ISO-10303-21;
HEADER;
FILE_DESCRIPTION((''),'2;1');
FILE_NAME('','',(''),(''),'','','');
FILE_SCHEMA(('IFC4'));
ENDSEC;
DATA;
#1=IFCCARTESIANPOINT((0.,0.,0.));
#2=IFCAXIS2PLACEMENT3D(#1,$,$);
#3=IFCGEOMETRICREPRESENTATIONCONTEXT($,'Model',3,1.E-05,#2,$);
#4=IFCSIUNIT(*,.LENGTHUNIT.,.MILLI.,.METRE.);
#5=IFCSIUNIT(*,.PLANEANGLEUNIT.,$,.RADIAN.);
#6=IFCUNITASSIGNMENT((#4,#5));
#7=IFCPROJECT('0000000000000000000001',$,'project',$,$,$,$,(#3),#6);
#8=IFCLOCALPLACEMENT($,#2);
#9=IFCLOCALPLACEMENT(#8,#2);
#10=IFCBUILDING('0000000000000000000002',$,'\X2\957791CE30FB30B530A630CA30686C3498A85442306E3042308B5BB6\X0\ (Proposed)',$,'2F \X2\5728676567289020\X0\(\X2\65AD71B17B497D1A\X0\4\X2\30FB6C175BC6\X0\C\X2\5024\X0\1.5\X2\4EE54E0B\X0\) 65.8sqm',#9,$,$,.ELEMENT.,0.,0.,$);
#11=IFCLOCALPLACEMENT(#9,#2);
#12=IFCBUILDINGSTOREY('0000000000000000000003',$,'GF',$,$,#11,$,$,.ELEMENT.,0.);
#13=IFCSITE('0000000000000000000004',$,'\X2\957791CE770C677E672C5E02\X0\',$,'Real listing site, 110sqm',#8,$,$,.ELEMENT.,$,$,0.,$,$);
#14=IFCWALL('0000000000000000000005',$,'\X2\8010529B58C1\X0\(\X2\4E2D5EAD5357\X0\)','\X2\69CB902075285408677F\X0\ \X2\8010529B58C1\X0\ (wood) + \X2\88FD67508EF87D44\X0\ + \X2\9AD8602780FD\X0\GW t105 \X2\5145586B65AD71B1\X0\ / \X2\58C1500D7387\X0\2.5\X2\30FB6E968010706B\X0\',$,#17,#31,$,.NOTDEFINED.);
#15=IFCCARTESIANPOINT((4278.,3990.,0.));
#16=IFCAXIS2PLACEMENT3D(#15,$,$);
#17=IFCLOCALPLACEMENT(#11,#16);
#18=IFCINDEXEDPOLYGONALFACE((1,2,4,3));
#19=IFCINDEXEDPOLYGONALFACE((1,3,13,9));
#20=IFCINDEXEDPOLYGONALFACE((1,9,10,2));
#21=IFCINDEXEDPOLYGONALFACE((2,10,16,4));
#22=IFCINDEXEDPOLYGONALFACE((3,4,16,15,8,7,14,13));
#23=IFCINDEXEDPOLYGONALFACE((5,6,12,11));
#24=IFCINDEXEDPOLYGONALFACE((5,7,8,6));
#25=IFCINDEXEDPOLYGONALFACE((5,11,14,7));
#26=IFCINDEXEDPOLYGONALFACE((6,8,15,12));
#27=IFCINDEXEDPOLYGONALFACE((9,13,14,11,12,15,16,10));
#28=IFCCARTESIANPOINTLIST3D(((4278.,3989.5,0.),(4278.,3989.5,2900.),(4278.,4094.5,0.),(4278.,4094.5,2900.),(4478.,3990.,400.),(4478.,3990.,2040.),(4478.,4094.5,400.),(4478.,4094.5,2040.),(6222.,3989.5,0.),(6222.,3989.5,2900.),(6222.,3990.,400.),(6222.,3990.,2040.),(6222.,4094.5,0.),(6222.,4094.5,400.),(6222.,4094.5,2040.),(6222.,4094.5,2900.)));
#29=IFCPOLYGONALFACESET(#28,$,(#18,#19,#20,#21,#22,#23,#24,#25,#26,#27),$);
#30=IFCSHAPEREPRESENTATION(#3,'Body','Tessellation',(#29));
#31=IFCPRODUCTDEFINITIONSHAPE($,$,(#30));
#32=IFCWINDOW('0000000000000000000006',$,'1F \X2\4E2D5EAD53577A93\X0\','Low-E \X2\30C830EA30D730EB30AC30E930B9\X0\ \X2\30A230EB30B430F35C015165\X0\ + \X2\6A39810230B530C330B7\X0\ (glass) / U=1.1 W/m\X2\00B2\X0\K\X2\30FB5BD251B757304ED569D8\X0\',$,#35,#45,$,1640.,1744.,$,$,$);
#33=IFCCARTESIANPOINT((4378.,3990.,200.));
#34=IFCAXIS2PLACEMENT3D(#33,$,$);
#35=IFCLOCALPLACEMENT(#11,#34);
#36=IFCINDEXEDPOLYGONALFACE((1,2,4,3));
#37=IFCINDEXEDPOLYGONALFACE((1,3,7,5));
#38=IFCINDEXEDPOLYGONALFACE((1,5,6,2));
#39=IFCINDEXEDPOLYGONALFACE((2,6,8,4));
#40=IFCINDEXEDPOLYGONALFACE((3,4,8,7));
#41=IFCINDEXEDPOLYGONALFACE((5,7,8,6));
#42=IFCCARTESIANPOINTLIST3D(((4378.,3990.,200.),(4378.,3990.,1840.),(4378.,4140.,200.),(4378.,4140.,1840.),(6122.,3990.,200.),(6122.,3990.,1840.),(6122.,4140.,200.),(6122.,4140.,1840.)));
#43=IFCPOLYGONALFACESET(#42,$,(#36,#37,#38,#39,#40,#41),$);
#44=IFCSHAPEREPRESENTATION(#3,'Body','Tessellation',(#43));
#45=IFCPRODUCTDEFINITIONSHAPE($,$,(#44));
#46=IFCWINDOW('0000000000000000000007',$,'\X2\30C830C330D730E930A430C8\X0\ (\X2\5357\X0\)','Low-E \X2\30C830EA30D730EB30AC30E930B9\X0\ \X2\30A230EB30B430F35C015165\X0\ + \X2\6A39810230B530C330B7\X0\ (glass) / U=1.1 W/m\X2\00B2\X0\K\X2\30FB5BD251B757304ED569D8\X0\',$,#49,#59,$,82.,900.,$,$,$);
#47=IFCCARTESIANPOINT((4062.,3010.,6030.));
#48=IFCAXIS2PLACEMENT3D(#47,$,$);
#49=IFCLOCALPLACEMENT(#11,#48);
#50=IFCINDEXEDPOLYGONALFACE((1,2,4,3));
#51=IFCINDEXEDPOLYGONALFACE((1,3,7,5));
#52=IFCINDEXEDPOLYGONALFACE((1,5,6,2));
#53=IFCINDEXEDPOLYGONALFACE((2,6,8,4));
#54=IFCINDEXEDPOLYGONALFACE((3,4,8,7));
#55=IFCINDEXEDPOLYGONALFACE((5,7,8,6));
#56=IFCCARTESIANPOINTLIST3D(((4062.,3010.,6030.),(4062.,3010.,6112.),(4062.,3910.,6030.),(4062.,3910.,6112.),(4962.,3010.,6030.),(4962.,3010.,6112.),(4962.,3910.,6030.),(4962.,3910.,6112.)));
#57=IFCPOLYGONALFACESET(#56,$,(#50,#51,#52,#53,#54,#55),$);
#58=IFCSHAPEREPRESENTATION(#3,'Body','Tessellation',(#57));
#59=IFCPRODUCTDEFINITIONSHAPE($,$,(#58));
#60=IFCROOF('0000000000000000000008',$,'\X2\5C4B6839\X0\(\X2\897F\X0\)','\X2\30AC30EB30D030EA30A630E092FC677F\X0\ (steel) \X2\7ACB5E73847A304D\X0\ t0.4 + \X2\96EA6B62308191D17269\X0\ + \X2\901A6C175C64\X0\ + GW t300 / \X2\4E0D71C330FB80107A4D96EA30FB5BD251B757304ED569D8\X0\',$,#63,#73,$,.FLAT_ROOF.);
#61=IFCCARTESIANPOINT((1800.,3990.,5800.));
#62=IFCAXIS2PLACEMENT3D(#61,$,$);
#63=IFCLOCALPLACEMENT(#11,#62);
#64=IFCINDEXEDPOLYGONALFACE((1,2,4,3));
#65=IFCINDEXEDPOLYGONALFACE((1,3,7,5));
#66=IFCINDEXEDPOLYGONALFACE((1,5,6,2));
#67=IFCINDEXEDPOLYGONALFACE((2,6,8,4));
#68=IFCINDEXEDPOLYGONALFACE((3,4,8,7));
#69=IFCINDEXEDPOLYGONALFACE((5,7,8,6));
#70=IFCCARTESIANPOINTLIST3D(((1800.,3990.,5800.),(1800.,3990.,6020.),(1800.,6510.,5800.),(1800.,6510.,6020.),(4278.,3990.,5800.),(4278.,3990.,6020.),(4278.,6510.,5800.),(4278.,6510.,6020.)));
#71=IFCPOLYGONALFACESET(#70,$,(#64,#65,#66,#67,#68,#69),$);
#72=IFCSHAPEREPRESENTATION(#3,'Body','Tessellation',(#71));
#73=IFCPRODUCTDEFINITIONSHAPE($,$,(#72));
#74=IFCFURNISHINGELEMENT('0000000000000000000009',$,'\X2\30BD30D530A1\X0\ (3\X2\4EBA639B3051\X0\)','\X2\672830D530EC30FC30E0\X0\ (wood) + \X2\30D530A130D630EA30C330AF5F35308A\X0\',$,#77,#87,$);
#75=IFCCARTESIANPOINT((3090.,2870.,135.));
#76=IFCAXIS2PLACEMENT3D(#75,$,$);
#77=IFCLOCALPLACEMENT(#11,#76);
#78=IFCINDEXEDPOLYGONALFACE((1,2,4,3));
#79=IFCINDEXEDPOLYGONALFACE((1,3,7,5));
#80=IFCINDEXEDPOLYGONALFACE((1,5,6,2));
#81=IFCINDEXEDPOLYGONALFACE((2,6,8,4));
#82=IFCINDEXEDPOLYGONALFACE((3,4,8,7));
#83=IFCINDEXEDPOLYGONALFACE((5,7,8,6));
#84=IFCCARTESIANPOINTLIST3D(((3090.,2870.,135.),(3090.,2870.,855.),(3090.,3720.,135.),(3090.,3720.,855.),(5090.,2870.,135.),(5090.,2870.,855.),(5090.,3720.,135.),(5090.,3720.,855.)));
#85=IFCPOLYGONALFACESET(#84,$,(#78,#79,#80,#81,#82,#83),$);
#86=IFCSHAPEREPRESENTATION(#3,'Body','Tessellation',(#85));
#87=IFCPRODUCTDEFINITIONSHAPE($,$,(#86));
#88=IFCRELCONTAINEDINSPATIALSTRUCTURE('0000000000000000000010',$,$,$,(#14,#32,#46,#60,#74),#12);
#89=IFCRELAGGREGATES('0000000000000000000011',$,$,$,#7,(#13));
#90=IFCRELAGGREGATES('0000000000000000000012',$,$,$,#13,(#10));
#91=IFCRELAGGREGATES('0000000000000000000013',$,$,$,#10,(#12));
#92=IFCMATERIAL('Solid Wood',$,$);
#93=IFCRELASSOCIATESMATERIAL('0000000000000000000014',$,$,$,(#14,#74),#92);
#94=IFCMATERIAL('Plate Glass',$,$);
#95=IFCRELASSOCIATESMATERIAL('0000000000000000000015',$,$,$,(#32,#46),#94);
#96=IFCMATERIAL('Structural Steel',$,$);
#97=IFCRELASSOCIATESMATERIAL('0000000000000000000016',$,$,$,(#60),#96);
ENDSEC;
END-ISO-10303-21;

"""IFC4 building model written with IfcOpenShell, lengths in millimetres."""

from ifc_helpers import new_model, si_unit, frame, frame_2d, origin, place, context, project, spatial, rectangle, extrude, material, element, fill, save


model = new_model("IFC4")

# Units and contexts
model_context = context("Model", 3, precision=1e-05, world=origin())
ifc_project = project(units=[si_unit("LENGTHUNIT", "METRE", prefix="MILLI"), si_unit("PLANEANGLEUNIT", "RADIAN")], contexts=[model_context])

# Site, building, storey
site_placement = place(None, origin())
site = spatial("IfcSite", under=ifc_project, at=site_placement, Name="長野県松本市", ObjectType="Real listing site, 110sqm", CompositionType="ELEMENT", RefElevation=0.0)
building_placement = place(site_placement, origin())
building = spatial("IfcBuilding", under=site, at=building_placement, Name="長野・サウナと水風呂のある家 (Proposed)", ObjectType="2F 在来木造(断熱等級4・気密C値1.5以下) 65.8sqm", CompositionType="ELEMENT", ElevationOfRefHeight=0.0, ElevationOfTerrain=0.0)
storey_placement = place(building_placement, origin())
storey = spatial("IfcBuildingStorey", under=building, at=storey_placement, Name="GF", CompositionType="ELEMENT", Elevation=0.0)

# Shared definitions
ifc_material_1 = material(Name="Solid Wood")

# Wall, opening, window
wall_1_placement = place(storey_placement, frame((4278.0, 3990.0, 0.0)))
wall_1 = element("IfcWall", 1, at=wall_1_placement, inside=storey, material=ifc_material_1, Name="耐力壁(中庭南)", Description="構造用合板 耐力壁 (wood) + 製材軸組 + 高性能GW t105 充填断熱 / 壁倍率2.5・準耐火", PredefinedType="NOTDEFINED", context=model_context, shape_type="SweptSolid", body=[
    extrude(rectangle(XDim=1944.0, YDim=105.0, at=frame_2d((972.0, 52.0))), frame((4278.0, 3990.0, 0.0)), (0.0, 0.0, 1.0), 2900.0),
])
opening_placement = place(storey_placement, frame((4378.0, 3990.0, 200.0)))
opening = element("IfcOpeningElement", 2, at=opening_placement, cuts=wall_1, PredefinedType="NOTDEFINED", context=model_context, shape_type="SweptSolid", body=[
    extrude(rectangle(XDim=1744.0, YDim=150.0, at=frame_2d((872.0, 75.0))), frame((4378.0, 3990.0, 200.0)), (0.0, 0.0, 1.0), 1640.0),
])
ifc_material_2 = material(Name="Plate Glass")
window_1_placement = place(storey_placement, frame((4378.0, 3990.0, 200.0)))
window_1 = element("IfcWindow", 3, at=window_1_placement, inside=storey, material=ifc_material_2, Name="1F 中庭南窓", Description="Low-E トリプルガラス アルゴン封入 + 樹脂サッシ (glass) / U=1.1 W/m²K・寒冷地仕様", OverallHeight=1640.0, OverallWidth=1744.0, context=model_context, shape_type="SweptSolid", body=[
    extrude(rectangle(XDim=1744.0, YDim=150.0, at=frame_2d((872.0, 75.0))), frame((4378.0, 3990.0, 200.0)), (0.0, 0.0, 1.0), 1640.0),
])
fill(opening, window_1)

# Window
window_2_placement = place(storey_placement, frame((4062.0, 3010.0, 6030.0)))
element("IfcWindow", 4, at=window_2_placement, inside=storey, material=ifc_material_2, Name="トップライト (南)", Description="Low-E トリプルガラス アルゴン封入 + 樹脂サッシ (glass) / U=1.1 W/m²K・寒冷地仕様", OverallHeight=82.0, OverallWidth=900.0, context=model_context, shape_type="SweptSolid", body=[
    extrude(rectangle(XDim=900.0, YDim=900.0, at=frame_2d((450.0, 450.0))), frame((4062.0, 3010.0, 6030.0)), (0.0, 0.0, 1.0), 82.0),
])

# Roof
ifc_material_3 = material(Name="Structural Steel")
for number, where, name in (
    (5, (1800.0, 3990.0, 5800.0), "屋根(西)"),
):
    element("IfcRoof", number, at=place(storey_placement, frame(where)), inside=storey, material=ifc_material_3, Name=name, Description="ガルバリウム鋼板 (steel) 立平葺き t0.4 + 雪止め金物 + 通気層 + GW t300 / 不燃・耐積雪・寒冷地仕様", PredefinedType="FLAT_ROOF", context=model_context, shape_type="SweptSolid", body=[
        extrude(rectangle(XDim=2478.0, YDim=2520.0, at=frame_2d((1239.0, 1260.0))), frame((1800.0, 3990.0, 5800.0)), (0.0, 0.0, 1.0), 220.0),
    ])

# Furnishing element
furnishing_placement = place(storey_placement, frame((3090.0, 2870.0, 135.0)))
element("IfcFurnishingElement", 6, at=furnishing_placement, inside=storey, material=ifc_material_1, Name="ソファ (3人掛け)", Description="木フレーム (wood) + ファブリック張り", context=model_context, shape_type="SweptSolid", body=[
    extrude(rectangle(XDim=2000.0, YDim=850.0, at=frame_2d((1000.0, 425.0))), frame((3090.0, 2870.0, 135.0)), (0.0, 0.0, 1.0), 720.0),
])

save(model, "model.ifc")
